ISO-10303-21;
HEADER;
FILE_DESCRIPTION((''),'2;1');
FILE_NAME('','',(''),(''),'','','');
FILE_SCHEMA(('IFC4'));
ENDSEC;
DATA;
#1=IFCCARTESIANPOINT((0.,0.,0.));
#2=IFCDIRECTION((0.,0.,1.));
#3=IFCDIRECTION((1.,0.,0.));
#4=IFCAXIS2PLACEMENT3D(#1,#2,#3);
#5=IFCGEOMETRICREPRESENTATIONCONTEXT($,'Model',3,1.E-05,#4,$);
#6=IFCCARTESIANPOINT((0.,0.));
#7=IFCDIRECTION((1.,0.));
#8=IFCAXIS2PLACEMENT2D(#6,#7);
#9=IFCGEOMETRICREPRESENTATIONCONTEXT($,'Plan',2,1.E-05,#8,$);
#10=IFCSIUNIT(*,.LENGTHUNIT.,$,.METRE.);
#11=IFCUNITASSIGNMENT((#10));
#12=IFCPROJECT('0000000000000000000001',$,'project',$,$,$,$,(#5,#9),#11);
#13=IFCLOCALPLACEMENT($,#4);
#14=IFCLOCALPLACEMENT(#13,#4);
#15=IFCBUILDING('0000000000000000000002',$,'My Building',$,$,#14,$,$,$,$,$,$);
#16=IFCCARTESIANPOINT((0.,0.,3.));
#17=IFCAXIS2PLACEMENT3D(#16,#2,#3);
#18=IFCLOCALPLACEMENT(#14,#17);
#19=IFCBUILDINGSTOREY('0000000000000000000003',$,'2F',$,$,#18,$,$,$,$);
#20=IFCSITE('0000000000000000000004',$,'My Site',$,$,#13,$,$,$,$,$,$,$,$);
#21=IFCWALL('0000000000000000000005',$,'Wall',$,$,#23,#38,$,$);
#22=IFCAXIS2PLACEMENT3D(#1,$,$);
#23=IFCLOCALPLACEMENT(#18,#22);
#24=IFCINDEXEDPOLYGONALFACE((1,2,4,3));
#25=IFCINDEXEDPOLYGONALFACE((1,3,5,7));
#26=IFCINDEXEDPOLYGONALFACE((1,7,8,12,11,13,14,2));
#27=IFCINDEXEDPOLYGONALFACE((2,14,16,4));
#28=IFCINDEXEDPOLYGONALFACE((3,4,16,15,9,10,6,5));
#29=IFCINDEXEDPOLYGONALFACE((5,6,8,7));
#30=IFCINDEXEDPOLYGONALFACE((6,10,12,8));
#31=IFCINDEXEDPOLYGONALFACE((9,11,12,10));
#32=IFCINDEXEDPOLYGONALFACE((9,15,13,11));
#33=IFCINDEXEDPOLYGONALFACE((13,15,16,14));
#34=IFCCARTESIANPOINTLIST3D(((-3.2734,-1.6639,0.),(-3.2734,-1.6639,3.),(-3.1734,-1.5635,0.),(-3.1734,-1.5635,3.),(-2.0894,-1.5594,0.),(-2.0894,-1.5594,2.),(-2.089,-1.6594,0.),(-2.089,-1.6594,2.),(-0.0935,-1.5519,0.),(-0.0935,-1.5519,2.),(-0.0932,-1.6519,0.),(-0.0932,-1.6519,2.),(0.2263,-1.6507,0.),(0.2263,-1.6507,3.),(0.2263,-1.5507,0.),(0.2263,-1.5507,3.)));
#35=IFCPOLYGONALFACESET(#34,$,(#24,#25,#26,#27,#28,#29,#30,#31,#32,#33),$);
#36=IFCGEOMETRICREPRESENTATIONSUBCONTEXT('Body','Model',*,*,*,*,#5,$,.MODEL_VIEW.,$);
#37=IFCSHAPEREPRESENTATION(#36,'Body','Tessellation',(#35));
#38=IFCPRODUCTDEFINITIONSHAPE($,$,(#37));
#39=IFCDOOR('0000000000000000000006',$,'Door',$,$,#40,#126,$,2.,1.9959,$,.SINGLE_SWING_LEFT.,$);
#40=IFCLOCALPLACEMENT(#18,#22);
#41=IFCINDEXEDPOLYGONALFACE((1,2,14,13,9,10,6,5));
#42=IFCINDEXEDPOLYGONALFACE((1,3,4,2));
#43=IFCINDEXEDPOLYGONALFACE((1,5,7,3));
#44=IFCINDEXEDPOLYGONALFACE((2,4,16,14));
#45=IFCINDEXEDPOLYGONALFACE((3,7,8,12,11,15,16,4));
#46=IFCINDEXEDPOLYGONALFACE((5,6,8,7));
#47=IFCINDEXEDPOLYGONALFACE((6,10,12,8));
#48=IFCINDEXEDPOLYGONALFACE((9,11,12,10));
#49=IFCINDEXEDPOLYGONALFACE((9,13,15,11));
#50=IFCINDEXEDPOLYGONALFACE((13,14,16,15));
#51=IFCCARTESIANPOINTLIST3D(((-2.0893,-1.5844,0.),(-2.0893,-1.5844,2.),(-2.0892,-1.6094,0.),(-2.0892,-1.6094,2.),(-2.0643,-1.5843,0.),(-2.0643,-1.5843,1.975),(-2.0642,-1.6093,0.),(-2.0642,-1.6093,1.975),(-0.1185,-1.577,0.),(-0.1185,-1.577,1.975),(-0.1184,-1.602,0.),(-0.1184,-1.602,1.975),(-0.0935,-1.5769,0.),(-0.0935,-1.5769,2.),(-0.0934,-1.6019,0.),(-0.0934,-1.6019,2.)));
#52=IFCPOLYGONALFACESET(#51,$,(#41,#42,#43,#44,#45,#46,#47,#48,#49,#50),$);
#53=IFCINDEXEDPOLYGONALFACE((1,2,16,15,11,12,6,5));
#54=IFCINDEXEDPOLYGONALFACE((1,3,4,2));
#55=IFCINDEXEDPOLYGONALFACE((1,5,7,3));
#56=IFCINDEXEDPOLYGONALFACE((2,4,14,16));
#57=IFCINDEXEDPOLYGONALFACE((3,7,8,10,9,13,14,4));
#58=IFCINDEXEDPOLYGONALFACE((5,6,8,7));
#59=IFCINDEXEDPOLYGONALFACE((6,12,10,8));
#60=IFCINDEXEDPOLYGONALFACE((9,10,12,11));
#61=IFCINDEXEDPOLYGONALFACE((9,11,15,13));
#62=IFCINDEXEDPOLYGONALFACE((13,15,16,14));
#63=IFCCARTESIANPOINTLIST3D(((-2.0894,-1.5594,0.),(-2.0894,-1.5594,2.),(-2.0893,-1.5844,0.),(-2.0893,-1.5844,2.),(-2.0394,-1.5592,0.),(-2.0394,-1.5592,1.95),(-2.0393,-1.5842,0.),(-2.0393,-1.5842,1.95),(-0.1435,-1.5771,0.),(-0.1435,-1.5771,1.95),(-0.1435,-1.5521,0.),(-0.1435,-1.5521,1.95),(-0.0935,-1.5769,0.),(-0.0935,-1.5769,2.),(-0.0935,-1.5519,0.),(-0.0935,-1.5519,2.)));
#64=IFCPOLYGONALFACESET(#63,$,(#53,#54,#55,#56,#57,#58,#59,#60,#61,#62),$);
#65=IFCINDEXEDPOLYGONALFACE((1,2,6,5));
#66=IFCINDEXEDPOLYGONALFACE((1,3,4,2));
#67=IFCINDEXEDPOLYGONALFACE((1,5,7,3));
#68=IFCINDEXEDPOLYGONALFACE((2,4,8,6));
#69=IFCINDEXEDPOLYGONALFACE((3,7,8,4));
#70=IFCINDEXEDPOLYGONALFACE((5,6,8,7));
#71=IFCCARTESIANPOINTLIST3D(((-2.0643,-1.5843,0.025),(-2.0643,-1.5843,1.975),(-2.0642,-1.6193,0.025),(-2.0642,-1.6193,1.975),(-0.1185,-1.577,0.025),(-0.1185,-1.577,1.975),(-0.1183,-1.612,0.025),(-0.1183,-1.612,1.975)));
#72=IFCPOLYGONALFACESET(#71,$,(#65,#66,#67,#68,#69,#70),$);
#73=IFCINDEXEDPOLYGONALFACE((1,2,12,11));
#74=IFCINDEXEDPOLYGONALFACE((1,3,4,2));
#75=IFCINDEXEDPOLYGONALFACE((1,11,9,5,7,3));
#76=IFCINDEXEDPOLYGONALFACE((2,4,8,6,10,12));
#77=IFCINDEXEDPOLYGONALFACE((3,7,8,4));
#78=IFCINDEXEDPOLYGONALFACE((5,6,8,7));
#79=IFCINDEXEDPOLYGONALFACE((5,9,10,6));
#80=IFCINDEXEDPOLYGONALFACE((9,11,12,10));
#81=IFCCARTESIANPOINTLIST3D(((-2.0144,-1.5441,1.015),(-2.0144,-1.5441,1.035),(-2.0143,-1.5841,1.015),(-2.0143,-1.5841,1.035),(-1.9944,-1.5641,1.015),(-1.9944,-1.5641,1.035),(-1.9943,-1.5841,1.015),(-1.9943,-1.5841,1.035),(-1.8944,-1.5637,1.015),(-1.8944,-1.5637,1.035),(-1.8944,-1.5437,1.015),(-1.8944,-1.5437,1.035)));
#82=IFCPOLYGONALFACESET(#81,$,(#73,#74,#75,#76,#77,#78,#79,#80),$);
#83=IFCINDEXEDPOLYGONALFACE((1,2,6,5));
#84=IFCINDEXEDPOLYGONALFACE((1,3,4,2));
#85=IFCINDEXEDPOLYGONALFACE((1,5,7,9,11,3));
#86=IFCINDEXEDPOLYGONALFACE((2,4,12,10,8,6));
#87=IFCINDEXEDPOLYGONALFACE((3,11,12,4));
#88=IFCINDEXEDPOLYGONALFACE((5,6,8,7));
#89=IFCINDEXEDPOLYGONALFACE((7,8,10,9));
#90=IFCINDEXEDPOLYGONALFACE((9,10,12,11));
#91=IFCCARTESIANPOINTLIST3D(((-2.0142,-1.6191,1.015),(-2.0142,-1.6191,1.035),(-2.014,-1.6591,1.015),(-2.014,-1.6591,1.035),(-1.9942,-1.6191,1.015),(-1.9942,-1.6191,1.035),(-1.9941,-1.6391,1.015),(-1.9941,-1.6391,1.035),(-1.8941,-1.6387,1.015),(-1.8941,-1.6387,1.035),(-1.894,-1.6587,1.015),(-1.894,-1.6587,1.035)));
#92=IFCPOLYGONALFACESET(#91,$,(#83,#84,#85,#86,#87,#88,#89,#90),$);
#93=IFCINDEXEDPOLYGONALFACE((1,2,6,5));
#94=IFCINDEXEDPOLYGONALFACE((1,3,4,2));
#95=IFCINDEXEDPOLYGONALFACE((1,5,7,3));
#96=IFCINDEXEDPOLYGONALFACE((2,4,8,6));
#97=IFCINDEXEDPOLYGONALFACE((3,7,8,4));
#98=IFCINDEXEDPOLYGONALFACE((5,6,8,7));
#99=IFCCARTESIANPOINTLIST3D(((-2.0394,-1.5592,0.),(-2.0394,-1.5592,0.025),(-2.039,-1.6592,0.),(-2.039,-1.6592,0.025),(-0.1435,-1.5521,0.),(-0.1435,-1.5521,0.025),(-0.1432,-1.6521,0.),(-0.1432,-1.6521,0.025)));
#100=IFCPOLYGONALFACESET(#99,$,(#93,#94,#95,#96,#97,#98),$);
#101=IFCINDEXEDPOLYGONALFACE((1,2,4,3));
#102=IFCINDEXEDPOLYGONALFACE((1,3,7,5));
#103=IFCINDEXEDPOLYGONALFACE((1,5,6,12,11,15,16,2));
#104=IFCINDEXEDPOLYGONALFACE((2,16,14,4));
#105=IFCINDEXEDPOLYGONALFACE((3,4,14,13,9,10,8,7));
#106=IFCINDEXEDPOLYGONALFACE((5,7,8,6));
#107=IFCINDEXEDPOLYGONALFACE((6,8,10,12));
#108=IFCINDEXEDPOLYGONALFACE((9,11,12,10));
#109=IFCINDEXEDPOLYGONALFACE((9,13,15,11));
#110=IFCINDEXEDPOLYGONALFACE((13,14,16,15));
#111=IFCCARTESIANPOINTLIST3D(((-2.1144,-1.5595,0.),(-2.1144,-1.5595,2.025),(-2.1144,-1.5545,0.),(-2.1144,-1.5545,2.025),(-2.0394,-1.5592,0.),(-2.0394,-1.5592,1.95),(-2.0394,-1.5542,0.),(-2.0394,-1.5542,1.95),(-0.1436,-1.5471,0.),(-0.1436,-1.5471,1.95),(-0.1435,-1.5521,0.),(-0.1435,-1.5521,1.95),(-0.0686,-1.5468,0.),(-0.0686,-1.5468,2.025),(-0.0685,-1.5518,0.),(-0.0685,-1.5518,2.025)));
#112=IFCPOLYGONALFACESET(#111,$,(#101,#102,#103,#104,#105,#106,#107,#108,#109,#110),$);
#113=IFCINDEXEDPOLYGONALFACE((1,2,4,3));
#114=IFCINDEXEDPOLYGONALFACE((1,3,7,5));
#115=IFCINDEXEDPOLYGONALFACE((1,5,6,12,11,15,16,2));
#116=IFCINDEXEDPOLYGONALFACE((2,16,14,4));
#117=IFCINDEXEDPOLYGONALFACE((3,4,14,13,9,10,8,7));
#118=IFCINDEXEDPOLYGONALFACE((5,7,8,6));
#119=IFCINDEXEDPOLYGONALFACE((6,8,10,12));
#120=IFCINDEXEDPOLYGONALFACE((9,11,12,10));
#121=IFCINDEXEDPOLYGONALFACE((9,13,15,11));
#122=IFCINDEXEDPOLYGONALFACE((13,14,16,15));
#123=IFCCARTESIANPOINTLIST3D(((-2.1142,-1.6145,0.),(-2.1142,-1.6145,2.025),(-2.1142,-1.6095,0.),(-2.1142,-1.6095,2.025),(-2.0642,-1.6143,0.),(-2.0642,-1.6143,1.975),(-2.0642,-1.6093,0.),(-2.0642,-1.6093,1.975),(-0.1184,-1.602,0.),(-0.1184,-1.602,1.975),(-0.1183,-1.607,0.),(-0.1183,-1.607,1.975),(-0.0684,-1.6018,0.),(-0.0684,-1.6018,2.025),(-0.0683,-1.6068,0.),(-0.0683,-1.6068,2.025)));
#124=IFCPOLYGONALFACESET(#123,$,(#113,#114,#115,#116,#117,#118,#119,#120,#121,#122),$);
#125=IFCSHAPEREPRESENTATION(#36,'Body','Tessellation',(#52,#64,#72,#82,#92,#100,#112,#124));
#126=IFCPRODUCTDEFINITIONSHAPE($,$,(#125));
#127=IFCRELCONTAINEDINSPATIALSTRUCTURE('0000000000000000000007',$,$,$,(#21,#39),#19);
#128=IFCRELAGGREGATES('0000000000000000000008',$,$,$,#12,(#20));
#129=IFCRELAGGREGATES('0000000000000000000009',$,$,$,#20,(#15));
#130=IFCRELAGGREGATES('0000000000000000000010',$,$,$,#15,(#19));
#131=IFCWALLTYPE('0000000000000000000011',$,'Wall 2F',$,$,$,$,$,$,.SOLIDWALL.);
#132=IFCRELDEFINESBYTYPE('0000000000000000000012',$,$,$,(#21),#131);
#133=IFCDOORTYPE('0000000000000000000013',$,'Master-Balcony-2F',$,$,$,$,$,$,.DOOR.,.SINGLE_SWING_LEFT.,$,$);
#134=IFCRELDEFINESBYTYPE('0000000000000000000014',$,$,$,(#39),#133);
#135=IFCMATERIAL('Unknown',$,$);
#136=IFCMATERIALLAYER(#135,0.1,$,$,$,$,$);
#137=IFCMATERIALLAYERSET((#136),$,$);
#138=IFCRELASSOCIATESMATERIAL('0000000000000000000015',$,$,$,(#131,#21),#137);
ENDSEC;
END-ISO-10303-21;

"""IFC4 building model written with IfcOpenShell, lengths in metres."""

from ifc_helpers import new_model, entity, si_unit, frame, origin_with_axes, origin_2d_with_axis, place, context, subcontext, project, spatial, line, indexed_curve, outline, extrude, shape, source, transform, mapped, material, layer, layer_set, layer_usage, type_object, type_shapes, element, fill, save


model = new_model("IFC4")

# Units and contexts
model_context = context("Model", 3, precision=1e-05, world=origin_with_axes())
plan_context = context("Plan", 2, precision=1e-05, world=origin_2d_with_axis())
body_context_1 = subcontext(model_context, "Body", "Model", "MODEL_VIEW")
body_context_2 = subcontext(plan_context, "Body", "Plan", "PLAN_VIEW")
ifc_project = project(units=[si_unit("LENGTHUNIT", "METRE")], contexts=[model_context, plan_context])

# Site, building, storey
site_placement = place(None, origin_with_axes())
site = spatial("IfcSite", under=ifc_project, at=site_placement, Name="My Site")
building_placement = place(site_placement, origin_with_axes())
building = spatial("IfcBuilding", under=site, at=building_placement, Name="My Building")
storey_placement = place(building_placement, frame((0.0, 0.0, 3.0), z_axis=(0.0, 0.0, 1.0), x_axis=(1.0, 0.0, 0.0)))
storey = spatial("IfcBuildingStorey", under=building, at=storey_placement, Name="2F")

# Shared definitions
ifc_material = material(Name="Unknown")

# Shared definitions
ifc_layer_1 = layer(ifc_material, 0.1)
ifc_layer_set_1 = layer_set([ifc_layer_1])
wall_type = type_object("IfcWallType", Name="Wall 2F", PredefinedType="SOLIDWALL", material=ifc_layer_set_1)

# Wall, opening, door
ifc_layer_usage_1 = layer_usage(ifc_layer_set_1, "AXIS2", "POSITIVE", 0.0)
wall_1_placement = place(storey_placement, frame((-3.2734, -1.6639, 0.0), z_axis=(0.0, 0.0, 1.0), x_axis=(0.999993, 0.003756, 0.0)))
wall_1 = element("IfcWall", 1, at=wall_1_placement, inside=storey, type_object=wall_type, material=ifc_layer_usage_1, Name="Wall", context=body_context_1, shape_type="SweptSolid", body=[
    extrude(outline(indexed_curve([(0.0, 0.0), (0.1004, 0.1), (3.5001, 0.1), (3.4997, 0.0)], segments=[line(1, 2, 3, 4, 1)])), origin_with_axes(), (0.0, 0.0, 1.0), 3.0),
])
shared_shape_1 = source(origin_with_axes(), body_context_1, "Body", "SweptSolid", [
    extrude(outline(indexed_curve([(0.0, 0.0), (1.9959, 0.0), (1.9959, 2.0), (0.0, 2.0)], segments=[line(1, 2, 3, 4, 1)])), frame((0.0, -0.6, 0.0), z_axis=(0.0, -1.0, 0.0), x_axis=(1.0, 0.0, 0.0)), (0.0, 0.0, -1.0), 1.2),
])
opening_1_placement = place(wall_1_placement, frame((3.1802, 0.1, 0.0), z_axis=(0.0, 0.0, 1.0), x_axis=(-1.0, 0.0, 0.0)))
opening_1 = element("IfcOpeningElement", 2, at=opening_1_placement, cuts=wall_1, PredefinedType="OPENING", context=body_context_1, shape_type="MappedRepresentation", body=[
    mapped(shared_shape_1, transform((0.0, 0.0, 0.0), x_axis=(1.0, 0.0, 0.0), y_axis=(0.0, 1.0, 0.0), z_axis=(0.0, 0.0, 1.0), scale=1.0)),
])
door_type_1 = type_object("IfcDoorType", Name="Master-Balcony-2F", OperationType="SINGLE_SWING_LEFT", PredefinedType="DOOR")
shared_shape_2 = source(origin_with_axes(), body_context_1, "Body", "SweptSolid", [
    extrude(outline(indexed_curve([(0.0, 0.0), (0.0, 2.0), (1.9959, 2.0), (1.9959, 0.0), (1.9709, 0.0), (1.9709, 1.975), (0.025, 1.975), (0.025, 0.0)], segments=[line(1, 2, 3, 4, 5, 6, 7, 8, 1)])), frame((0.0, 0.025, 0.0), z_axis=(0.0, -1.0, 0.0), x_axis=(1.0, 0.0, 0.0)), (0.0, 0.0, -1.0), 0.025),
    extrude(outline(indexed_curve([(0.0, 0.0), (0.0, 2.0), (1.9959, 2.0), (1.9959, 0.0), (1.9459, 0.0), (1.9459, 1.95), (0.05, 1.95), (0.05, 0.0)], segments=[line(1, 2, 3, 4, 5, 6, 7, 8, 1)])), frame((0.0, 0.0, 0.0), z_axis=(0.0, -1.0, 0.0), x_axis=(1.0, 0.0, 0.0)), (0.0, 0.0, -1.0), 0.025),
    extrude(outline(indexed_curve([(0.0, 0.0), (1.9459, 0.0), (1.9459, 0.035), (0.0, 0.035)], segments=[line(1, 2, 3, 4, 1)])), frame((0.025, 0.025, 0.025), z_axis=(0.0, 0.0, 1.0), x_axis=(1.0, 0.0, 0.0)), (0.0, 0.0, 1.0), 1.95),
    extrude(outline(indexed_curve([(0.0, 0.0), (0.0, -0.04), (-0.12, -0.04), (-0.12, -0.02), (-0.02, -0.02), (-0.02, 0.0)], segments=[line(1, 2, 3, 4, 5, 6, 1)])), frame((1.9209, 0.025, 1.015), z_axis=(0.0, 0.0, 1.0), x_axis=(1.0, 0.0, 0.0)), (0.0, 0.0, 1.0), 0.02),
    extrude(outline(indexed_curve([(0.0, 0.0), (0.0, 0.04), (-0.12, 0.04), (-0.12, 0.02), (-0.02, 0.02), (-0.02, 0.0)], segments=[line(1, 2, 3, 4, 5, 6, 1)])), frame((1.9209, 0.06, 1.015), z_axis=(0.0, 0.0, 1.0), x_axis=(1.0, 0.0, 0.0)), (0.0, 0.0, 1.0), 0.02),
    extrude(outline(indexed_curve([(0.0, 0.0), (1.8959, 0.0), (1.8959, 0.1), (0.0, 0.1)], segments=[line(1, 2, 3, 4, 1)])), frame((0.05, 0.0, 0.0), z_axis=(0.0, 0.0, 1.0), x_axis=(1.0, 0.0, 0.0)), (0.0, 0.0, 1.0), 0.025),
    extrude(outline(indexed_curve([(0.0, 0.0), (0.0, 2.025), (2.0459, 2.025), (2.0459, 0.0), (1.9709, 0.0), (1.9709, 1.95), (0.075, 1.95), (0.075, 0.0)], segments=[line(1, 2, 3, 4, 5, 6, 7, 8, 1)])), frame((-0.025, -0.005, 0.0), z_axis=(0.0, -1.0, 0.0), x_axis=(1.0, 0.0, 0.0)), (0.0, 0.0, -1.0), 0.005),
    extrude(outline(indexed_curve([(0.0, 0.0), (0.0, 2.025), (2.0459, 2.025), (2.0459, 0.0), (1.9959, 0.0), (1.9959, 1.975), (0.05, 1.975), (0.05, 0.0)], segments=[line(1, 2, 3, 4, 5, 6, 7, 8, 1)])), frame((-0.025, 0.05, 0.0), z_axis=(0.0, -1.0, 0.0), x_axis=(1.0, 0.0, 0.0)), (0.0, 0.0, -1.0), 0.005),
])
shared_shape_3 = source(origin_with_axes(), body_context_2, "Body", "Curve2D", [
    entity("IfcIndexedPolyCurve", entity("IfcCartesianPointList2D", [[0.0, 0.0], [0.0, 0.05], [0.025, 0.05], [0.025, 0.025], [0.05, 0.025], [0.05, 0.0]]), [entity("IfcLineIndex", [1, 2, 3, 4, 5, 6, 1])]),
    entity("IfcIndexedPolyCurve", entity("IfcCartesianPointList2D", [[1.9959, 0.0], [1.9959, 0.05], [1.9709, 0.05], [1.9709, 0.025], [1.9459, 0.025], [1.9459, 0.0]]), [entity("IfcLineIndex", [1, 2, 3, 4, 5, 6, 1])]),
    entity("IfcTrimmedCurve", entity("IfcEllipse", entity("IfcAxis2Placement2D", entity("IfcCartesianPoint", [0.06, 0.05]), entity("IfcDirection", [1.0, 0.0])), 1.9109, 1.9459), [entity("IfcCartesianPoint", [1.9709, 0.05])], [entity("IfcCartesianPoint", [0.06, 1.9959])], True, "CARTESIAN"),
    entity("IfcIndexedPolyCurve", entity("IfcCartesianPointList2D", [[0.025, 0.05], [0.06, 0.05], [0.06, 1.9959], [0.025, 1.9959]]), [entity("IfcLineIndex", [1, 2, 3, 4, 1])]),
])
type_shapes(door_type_1, [shared_shape_2, shared_shape_3])
door_1_placement = place(opening_1_placement, frame((0.0, 0.0, 0.0), z_axis=(0.0, 0.0, 1.0), x_axis=(1.0, 0.0, 0.0)))
door_1 = element("IfcDoor", 3, at=door_1_placement, inside=storey, type_object=door_type_1, Name="Door", OperationType="SINGLE_SWING_LEFT", OverallHeight=2.0, OverallWidth=1.9959, shapes=[
    shape(body_context_1, "Body", "MappedRepresentation", [mapped(shared_shape_2, transform((0.0, 0.0, 0.0), x_axis=(1.0, 0.0, 0.0), y_axis=(0.0, 1.0, 0.0), z_axis=(0.0, 0.0, 1.0), scale=1.0))]),
    shape(body_context_2, "Body", "MappedRepresentation", [mapped(shared_shape_3, transform((0.0, 0.0, 0.0), x_axis=(1.0, 0.0, 0.0), y_axis=(0.0, 1.0, 0.0), z_axis=(0.0, 0.0, 1.0), scale=1.0))]),
])
fill(opening_1, door_1)

save(model, "model.ifc")
